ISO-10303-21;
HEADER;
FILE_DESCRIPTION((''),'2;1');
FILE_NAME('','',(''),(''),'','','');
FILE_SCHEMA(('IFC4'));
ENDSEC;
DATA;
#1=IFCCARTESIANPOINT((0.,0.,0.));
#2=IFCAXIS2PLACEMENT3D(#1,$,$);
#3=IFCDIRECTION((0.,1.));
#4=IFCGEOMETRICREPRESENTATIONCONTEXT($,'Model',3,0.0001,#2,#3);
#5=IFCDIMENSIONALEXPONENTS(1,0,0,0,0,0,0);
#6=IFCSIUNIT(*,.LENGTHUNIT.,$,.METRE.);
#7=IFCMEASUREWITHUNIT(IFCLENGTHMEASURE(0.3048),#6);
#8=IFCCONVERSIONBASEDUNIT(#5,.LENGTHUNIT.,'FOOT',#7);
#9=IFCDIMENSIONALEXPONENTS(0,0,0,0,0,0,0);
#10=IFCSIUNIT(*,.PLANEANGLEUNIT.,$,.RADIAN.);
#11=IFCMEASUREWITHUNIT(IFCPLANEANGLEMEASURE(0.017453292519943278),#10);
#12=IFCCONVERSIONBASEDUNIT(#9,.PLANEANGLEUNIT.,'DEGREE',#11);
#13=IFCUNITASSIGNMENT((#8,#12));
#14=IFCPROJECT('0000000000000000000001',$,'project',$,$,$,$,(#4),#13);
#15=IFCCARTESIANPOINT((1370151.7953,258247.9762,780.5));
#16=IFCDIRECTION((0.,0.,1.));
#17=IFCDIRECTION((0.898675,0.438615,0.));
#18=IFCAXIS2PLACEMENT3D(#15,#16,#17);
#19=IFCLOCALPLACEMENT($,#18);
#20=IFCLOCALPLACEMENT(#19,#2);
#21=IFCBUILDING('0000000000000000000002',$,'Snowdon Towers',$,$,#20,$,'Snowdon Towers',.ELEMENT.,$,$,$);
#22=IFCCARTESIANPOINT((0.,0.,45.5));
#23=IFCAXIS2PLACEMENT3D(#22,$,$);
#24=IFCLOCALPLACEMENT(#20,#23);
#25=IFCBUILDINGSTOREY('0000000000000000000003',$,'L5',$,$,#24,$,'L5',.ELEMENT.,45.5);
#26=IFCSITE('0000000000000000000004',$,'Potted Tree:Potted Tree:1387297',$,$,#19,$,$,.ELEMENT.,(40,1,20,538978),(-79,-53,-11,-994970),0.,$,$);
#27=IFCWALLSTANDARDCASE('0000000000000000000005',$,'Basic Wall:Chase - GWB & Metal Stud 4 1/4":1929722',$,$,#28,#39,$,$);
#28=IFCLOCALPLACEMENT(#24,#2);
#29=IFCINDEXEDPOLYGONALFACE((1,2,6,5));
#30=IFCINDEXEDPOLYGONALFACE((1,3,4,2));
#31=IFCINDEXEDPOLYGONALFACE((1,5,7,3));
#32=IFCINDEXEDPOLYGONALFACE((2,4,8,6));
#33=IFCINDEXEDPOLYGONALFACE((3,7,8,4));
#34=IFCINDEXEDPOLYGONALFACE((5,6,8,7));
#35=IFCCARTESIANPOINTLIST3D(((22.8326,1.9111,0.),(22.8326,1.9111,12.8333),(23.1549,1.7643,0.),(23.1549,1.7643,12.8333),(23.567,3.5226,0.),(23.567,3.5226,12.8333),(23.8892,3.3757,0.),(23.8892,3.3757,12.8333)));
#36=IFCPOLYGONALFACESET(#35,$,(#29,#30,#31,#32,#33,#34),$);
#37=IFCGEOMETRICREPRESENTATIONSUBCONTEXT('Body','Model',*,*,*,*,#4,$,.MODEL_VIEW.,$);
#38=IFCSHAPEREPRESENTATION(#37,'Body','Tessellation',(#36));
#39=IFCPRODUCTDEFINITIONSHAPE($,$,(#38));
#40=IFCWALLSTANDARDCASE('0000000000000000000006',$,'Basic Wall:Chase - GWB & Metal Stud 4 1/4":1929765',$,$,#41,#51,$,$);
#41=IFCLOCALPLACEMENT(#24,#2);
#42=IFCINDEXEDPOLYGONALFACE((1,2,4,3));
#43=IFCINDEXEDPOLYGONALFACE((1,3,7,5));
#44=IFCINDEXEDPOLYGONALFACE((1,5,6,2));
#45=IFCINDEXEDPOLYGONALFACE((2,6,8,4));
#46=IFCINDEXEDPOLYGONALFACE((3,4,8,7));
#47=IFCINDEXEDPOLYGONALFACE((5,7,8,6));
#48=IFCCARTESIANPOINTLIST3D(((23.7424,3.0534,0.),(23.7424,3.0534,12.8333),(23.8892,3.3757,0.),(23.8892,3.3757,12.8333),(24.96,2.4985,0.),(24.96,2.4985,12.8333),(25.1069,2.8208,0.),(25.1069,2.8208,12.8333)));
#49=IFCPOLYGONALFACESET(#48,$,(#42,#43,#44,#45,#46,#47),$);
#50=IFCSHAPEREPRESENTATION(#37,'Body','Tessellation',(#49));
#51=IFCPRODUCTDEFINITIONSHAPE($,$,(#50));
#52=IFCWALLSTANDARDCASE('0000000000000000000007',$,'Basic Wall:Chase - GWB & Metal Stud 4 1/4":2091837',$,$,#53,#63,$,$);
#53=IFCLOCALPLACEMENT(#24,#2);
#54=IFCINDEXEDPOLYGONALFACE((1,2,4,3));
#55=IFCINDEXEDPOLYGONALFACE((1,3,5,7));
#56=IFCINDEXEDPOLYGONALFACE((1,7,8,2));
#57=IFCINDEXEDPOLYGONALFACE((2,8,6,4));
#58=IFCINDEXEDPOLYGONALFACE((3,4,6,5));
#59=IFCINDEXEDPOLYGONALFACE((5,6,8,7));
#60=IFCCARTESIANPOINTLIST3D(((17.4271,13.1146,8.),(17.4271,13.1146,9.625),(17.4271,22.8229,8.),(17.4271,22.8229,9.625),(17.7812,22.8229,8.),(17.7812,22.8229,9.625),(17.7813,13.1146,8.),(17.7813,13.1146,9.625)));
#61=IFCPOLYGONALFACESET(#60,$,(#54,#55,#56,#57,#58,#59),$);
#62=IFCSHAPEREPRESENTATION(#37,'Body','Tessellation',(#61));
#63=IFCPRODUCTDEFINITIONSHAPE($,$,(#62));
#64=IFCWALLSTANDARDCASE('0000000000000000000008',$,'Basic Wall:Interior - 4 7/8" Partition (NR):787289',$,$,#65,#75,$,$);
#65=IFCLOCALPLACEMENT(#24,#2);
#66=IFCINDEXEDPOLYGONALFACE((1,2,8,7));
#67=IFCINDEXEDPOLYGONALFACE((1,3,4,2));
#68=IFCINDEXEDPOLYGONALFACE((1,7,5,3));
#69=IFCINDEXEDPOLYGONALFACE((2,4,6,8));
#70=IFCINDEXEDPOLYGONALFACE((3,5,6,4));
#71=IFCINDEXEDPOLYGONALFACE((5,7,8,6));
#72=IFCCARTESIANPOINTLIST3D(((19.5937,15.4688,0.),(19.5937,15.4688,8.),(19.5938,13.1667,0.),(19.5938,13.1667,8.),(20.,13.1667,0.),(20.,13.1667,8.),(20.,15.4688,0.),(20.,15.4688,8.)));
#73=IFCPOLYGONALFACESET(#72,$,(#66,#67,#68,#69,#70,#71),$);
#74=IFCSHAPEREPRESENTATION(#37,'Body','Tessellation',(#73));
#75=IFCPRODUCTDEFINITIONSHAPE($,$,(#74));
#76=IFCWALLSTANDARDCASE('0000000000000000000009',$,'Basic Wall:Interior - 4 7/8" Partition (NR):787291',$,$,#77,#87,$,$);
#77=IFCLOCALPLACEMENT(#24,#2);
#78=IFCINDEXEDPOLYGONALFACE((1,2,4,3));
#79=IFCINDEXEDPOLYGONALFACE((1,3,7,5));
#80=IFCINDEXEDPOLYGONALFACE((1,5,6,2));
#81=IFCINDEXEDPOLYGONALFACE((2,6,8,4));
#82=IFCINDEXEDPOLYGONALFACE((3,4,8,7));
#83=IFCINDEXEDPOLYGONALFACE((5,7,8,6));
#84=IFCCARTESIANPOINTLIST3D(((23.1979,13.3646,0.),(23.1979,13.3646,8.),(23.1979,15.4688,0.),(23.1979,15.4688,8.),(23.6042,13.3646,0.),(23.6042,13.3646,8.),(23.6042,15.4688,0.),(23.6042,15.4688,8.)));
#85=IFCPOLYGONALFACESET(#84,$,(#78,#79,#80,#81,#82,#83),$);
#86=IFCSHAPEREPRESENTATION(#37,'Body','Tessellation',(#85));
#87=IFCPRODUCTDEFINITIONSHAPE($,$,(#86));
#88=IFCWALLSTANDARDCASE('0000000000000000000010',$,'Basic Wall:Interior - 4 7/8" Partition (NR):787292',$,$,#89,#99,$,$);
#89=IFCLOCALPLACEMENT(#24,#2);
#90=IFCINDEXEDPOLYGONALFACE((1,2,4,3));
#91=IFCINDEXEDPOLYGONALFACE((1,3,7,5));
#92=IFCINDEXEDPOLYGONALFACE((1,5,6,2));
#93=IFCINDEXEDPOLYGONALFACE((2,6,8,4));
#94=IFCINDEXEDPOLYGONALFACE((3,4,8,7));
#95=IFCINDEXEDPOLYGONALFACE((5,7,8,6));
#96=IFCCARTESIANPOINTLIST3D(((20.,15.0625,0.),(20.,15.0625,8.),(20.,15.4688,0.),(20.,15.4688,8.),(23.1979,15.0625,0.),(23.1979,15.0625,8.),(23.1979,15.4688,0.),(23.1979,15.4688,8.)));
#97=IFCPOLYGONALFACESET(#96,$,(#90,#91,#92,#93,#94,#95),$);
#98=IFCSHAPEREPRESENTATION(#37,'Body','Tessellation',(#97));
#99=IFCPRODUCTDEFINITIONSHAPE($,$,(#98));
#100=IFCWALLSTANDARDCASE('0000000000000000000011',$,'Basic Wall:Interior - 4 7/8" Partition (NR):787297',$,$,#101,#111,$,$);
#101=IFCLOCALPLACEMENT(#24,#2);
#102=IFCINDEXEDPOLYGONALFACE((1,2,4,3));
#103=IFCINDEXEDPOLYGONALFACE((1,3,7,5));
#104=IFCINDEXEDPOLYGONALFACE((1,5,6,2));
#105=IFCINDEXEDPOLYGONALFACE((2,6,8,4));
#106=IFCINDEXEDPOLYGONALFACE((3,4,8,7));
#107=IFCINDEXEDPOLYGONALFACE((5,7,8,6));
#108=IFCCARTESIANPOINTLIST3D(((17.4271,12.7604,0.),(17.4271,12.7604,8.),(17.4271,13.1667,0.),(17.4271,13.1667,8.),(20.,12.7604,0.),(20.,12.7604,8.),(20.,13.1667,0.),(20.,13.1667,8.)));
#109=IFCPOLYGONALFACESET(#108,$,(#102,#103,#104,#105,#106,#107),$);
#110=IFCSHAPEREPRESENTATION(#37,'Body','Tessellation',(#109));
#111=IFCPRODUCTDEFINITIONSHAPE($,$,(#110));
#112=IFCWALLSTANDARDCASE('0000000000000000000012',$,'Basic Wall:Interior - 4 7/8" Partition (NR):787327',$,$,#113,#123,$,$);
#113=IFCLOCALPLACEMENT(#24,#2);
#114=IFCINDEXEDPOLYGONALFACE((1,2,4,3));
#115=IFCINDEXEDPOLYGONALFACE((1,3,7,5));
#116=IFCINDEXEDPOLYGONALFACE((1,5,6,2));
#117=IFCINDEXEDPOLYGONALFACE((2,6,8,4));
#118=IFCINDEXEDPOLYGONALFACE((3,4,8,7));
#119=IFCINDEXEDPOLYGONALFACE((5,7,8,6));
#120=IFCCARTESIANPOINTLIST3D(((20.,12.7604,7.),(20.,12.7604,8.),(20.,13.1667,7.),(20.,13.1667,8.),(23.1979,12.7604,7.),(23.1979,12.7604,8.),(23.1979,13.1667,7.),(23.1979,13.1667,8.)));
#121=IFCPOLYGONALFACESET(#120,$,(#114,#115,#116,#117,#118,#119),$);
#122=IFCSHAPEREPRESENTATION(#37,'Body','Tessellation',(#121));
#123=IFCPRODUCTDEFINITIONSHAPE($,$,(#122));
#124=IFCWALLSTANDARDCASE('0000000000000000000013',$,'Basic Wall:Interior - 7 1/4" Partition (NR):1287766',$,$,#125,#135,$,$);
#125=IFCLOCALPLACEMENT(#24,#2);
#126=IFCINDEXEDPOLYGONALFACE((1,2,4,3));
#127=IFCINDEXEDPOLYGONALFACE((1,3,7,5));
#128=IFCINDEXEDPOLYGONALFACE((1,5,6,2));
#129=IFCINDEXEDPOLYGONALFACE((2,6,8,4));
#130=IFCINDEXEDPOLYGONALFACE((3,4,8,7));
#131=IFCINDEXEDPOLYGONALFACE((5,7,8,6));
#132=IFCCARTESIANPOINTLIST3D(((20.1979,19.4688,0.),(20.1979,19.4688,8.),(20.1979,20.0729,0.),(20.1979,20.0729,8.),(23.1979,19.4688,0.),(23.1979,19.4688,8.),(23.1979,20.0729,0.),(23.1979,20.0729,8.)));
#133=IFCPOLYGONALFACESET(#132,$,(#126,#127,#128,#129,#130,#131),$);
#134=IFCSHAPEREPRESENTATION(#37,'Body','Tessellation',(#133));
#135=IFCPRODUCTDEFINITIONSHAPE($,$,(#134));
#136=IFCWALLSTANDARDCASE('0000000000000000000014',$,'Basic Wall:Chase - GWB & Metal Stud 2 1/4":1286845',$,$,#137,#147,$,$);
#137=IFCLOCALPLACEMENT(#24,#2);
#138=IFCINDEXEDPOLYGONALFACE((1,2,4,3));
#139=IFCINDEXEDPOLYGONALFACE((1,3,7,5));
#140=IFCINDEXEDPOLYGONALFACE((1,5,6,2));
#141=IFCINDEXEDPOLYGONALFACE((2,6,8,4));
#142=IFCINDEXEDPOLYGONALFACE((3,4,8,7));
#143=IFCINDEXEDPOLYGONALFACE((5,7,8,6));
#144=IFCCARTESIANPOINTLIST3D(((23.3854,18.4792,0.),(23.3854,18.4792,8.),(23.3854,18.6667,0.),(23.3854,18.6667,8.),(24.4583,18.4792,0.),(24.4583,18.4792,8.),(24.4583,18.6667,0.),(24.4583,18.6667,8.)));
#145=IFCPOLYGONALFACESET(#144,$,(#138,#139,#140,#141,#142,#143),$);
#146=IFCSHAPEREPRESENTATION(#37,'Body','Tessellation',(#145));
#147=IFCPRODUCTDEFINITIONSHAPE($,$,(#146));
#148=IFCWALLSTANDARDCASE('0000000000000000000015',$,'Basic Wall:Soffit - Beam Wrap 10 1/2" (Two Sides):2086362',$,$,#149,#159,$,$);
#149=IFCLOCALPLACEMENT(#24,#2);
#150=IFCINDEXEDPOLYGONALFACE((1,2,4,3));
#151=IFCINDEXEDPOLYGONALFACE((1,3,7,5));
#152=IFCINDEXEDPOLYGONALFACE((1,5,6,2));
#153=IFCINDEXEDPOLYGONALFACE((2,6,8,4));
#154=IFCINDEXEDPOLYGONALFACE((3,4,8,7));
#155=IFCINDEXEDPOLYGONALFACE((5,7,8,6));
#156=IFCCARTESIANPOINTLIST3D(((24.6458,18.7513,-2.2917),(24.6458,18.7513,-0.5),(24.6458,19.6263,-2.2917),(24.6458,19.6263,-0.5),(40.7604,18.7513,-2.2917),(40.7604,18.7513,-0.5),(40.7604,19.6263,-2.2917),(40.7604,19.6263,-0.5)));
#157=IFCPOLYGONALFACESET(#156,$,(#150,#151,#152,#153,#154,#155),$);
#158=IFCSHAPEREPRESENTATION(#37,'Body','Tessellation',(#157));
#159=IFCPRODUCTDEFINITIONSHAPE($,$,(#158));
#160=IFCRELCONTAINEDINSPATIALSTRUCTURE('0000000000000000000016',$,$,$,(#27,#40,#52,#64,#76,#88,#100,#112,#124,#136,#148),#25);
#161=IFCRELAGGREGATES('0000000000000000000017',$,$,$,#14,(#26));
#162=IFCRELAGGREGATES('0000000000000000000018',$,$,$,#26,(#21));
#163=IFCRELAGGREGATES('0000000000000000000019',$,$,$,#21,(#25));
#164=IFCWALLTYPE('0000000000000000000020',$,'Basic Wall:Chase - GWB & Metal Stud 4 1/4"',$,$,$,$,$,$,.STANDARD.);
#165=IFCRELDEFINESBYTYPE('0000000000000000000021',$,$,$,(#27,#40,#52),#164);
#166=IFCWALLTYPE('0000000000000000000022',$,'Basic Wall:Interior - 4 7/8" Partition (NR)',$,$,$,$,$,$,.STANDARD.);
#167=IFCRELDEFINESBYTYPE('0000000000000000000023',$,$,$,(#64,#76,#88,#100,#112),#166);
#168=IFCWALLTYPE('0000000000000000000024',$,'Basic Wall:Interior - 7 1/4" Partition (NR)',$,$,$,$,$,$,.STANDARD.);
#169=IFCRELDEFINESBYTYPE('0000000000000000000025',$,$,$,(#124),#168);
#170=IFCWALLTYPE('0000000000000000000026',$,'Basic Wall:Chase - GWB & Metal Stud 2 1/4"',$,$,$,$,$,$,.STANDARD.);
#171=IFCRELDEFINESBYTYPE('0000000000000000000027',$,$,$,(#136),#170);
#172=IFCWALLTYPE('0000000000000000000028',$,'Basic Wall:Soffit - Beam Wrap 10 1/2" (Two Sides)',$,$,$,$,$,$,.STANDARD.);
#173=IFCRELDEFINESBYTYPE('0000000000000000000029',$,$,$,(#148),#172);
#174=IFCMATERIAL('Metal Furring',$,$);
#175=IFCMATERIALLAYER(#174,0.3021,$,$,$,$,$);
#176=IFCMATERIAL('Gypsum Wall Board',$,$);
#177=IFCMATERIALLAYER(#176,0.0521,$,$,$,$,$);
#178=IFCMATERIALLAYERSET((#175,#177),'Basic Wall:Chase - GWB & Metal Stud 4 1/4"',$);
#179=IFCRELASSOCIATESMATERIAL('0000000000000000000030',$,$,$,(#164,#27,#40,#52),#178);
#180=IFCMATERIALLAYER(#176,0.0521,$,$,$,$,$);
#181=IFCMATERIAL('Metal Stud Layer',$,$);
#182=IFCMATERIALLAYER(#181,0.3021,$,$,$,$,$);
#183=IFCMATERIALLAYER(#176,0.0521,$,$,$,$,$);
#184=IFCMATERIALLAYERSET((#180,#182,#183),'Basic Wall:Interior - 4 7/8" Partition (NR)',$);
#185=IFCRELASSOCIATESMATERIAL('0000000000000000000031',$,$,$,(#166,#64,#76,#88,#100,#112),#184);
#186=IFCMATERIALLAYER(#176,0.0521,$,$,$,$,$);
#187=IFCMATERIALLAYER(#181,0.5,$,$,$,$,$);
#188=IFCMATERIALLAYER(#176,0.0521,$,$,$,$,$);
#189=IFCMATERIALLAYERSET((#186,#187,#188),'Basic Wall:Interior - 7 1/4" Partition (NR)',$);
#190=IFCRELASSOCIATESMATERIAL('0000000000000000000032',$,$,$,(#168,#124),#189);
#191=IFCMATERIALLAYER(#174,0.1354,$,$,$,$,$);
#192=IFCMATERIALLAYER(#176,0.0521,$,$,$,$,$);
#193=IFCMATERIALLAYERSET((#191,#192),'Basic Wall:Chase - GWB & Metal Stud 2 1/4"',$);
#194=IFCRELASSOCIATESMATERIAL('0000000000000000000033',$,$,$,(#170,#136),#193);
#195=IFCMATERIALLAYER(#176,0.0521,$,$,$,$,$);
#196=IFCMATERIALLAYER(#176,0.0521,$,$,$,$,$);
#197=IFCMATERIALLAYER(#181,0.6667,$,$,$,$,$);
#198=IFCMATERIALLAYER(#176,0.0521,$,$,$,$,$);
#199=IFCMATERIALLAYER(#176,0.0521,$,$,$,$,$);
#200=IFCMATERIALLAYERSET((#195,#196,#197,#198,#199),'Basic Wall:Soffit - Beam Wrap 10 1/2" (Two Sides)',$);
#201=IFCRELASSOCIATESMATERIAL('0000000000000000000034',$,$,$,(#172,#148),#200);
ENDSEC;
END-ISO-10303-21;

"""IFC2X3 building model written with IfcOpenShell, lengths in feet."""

from ifc_helpers import new_model, entity, si_unit, converted_unit, direction, frame, frame_2d, origin, place, context, subcontext, project, spatial, rectangle, extrude, material, layer, layer_set, layer_usage, type_object, element, save


model = new_model("IFC2X3")

# Units and contexts
model_context = context("Model", 3, precision=0.0001, world=origin(), true_north=direction((0.0, 1.0)))
body_context = subcontext(model_context, "Body", "Model", "MODEL_VIEW")
ifc_project = project(units=[converted_unit("LENGTHUNIT", "FOOT", entity("IfcLengthMeasure", 0.3048), si_unit("LENGTHUNIT", "METRE"), dimensions=[1, 0, 0, 0, 0, 0, 0]), converted_unit("PLANEANGLEUNIT", "DEGREE", entity("IfcPlaneAngleMeasure", 0.017453292519943278), si_unit("PLANEANGLEUNIT", "RADIAN"), dimensions=[0, 0, 0, 0, 0, 0, 0])], contexts=[model_context])

# Site, building, storey
site_placement = place(None, frame((1370151.7953, 258247.9762, 780.5), z_axis=(0.0, 0.0, 1.0), x_axis=(0.898675, 0.438615, 0.0)))
site = spatial("IfcSite", under=ifc_project, at=site_placement, Name="Potted Tree:Potted Tree:1387297", CompositionType="ELEMENT", RefLatitude=(40, 1, 20, 538978), RefLongitude=(-79, -53, -11, -994970), RefElevation=0.0)
building_placement = place(site_placement, origin())
building = spatial("IfcBuilding", under=site, at=building_placement, Name="Snowdon Towers", LongName="Snowdon Towers", CompositionType="ELEMENT")
storey_placement = place(building_placement, frame((0.0, 0.0, 45.5)))
storey = spatial("IfcBuildingStorey", under=building, at=storey_placement, Name="L5", LongName="L5", CompositionType="ELEMENT", Elevation=45.5)

# Walls
ifc_material_1 = material(Name="Metal Furring")
ifc_layer_1 = layer(ifc_material_1, 0.3021)
ifc_material_2 = material(Name="Gypsum Wall Board")
ifc_layer_2 = layer(ifc_material_2, 0.0521)
ifc_layer_set_1 = layer_set([ifc_layer_1, ifc_layer_2], Name="Basic Wall:Chase - GWB & Metal Stud 4 1/4\"")
ifc_layer_usage_1 = layer_usage(ifc_layer_set_1, "AXIS2", "POSITIVE", -0.1771)
wall_type_1 = type_object("IfcWallType", Name="Basic Wall:Chase - GWB & Metal Stud 4 1/4\"", PredefinedType="STANDARD", material=ifc_layer_set_1)
wall_1_placement = place(storey_placement, frame((22.9938, 1.8377, 0.0), z_axis=(0.0, 0.0, 1.0), x_axis=(0.414671, 0.909972, 0.0)))
element("IfcWallStandardCase", 1, at=wall_1_placement, inside=storey, type_object=wall_type_1, material=ifc_layer_usage_1, Name="Basic Wall:Chase - GWB & Metal Stud 4 1/4\":1929722", context=body_context, shape_type="SweptSolid", body=[
    extrude(rectangle(XDim=1.7708, YDim=0.3542, at=frame_2d((0.8854, 0.0), x_axis=(-1.0, 0.0))), origin(), (0.0, 0.0, 1.0), 12.8333),
])
ifc_layer_usage_2 = layer_usage(ifc_layer_set_1, "AXIS2", "POSITIVE", -0.1771)
wall_2_placement = place(storey_placement, frame((23.8158, 3.2145, 0.0), z_axis=(0.0, 0.0, 1.0), x_axis=(0.909972, -0.414671, 0.0)))
element("IfcWallStandardCase", 2, at=wall_2_placement, inside=storey, type_object=wall_type_1, material=ifc_layer_usage_2, Name="Basic Wall:Chase - GWB & Metal Stud 4 1/4\":1929765", context=body_context, shape_type="SweptSolid", body=[
    extrude(rectangle(XDim=1.3381, YDim=0.3542, at=frame_2d((0.6691, 0.0), x_axis=(-1.0, 0.0))), origin(), (0.0, 0.0, 1.0), 12.8333),
])
ifc_layer_usage_3 = layer_usage(ifc_layer_set_1, "AXIS2", "POSITIVE", -0.1771)
wall_3_placement = place(storey_placement, frame((17.6042, 13.1146, 8.0), z_axis=(0.0, 0.0, 1.0), x_axis=(0.0, 1.0, 0.0)))
element("IfcWallStandardCase", 3, at=wall_3_placement, inside=storey, type_object=wall_type_1, material=ifc_layer_usage_3, Name="Basic Wall:Chase - GWB & Metal Stud 4 1/4\":2091837", context=body_context, shape_type="SweptSolid", body=[
    extrude(rectangle(XDim=9.7083, YDim=0.3542, at=frame_2d((4.8542, 0.0), x_axis=(-1.0, 0.0))), origin(), (0.0, 0.0, 1.0), 1.625),
])
ifc_layer_3 = layer(ifc_material_2, 0.0521)
ifc_material_3 = material(Name="Metal Stud Layer")
ifc_layer_4 = layer(ifc_material_3, 0.3021)
ifc_layer_5 = layer(ifc_material_2, 0.0521)
ifc_layer_set_2 = layer_set([ifc_layer_3, ifc_layer_4, ifc_layer_5], Name="Basic Wall:Interior - 4 7/8\" Partition (NR)")
ifc_layer_usage_4 = layer_usage(ifc_layer_set_2, "AXIS2", "NEGATIVE", 0.2031)
wall_type_2 = type_object("IfcWallType", Name="Basic Wall:Interior - 4 7/8\" Partition (NR)", PredefinedType="STANDARD", material=ifc_layer_set_2)
wall_4_placement = place(storey_placement, frame((19.7969, 13.1667, 0.0), z_axis=(0.0, 0.0, 1.0), x_axis=(0.0, 1.0, 0.0)))
element("IfcWallStandardCase", 4, at=wall_4_placement, inside=storey, type_object=wall_type_2, material=ifc_layer_usage_4, Name="Basic Wall:Interior - 4 7/8\" Partition (NR):787289", context=body_context, shape_type="SweptSolid", body=[
    extrude(rectangle(XDim=2.3021, YDim=0.4062, at=frame_2d((1.151, 0.0), x_axis=(-1.0, 0.0))), origin(), (0.0, 0.0, 1.0), 8.0),
])
ifc_layer_usage_5 = layer_usage(ifc_layer_set_2, "AXIS2", "NEGATIVE", 0.2031)
wall_5_placement = place(storey_placement, frame((23.401, 13.3646, 0.0), z_axis=(0.0, 0.0, 1.0), x_axis=(0.0, 1.0, 0.0)))
element("IfcWallStandardCase", 5, at=wall_5_placement, inside=storey, type_object=wall_type_2, material=ifc_layer_usage_5, Name="Basic Wall:Interior - 4 7/8\" Partition (NR):787291", context=body_context, shape_type="SweptSolid", body=[
    extrude(rectangle(XDim=2.1042, YDim=0.4062, at=frame_2d((1.0521, 0.0), x_axis=(-1.0, 0.0))), origin(), (0.0, 0.0, 1.0), 8.0),
])
ifc_layer_usage_6 = layer_usage(ifc_layer_set_2, "AXIS2", "NEGATIVE", 0.2031)
wall_6_placement = place(storey_placement, frame((23.1979, 15.2656, 0.0), z_axis=(0.0, 0.0, 1.0), x_axis=(-1.0, 0.0, 0.0)))
element("IfcWallStandardCase", 6, at=wall_6_placement, inside=storey, type_object=wall_type_2, material=ifc_layer_usage_6, Name="Basic Wall:Interior - 4 7/8\" Partition (NR):787292", context=body_context, shape_type="SweptSolid", body=[
    extrude(rectangle(XDim=3.1979, YDim=0.4062, at=frame_2d((1.599, 0.0), x_axis=(-1.0, 0.0))), origin(), (0.0, 0.0, 1.0), 8.0),
])
ifc_layer_usage_7 = layer_usage(ifc_layer_set_2, "AXIS2", "NEGATIVE", 0.2031)
wall_7_placement = place(storey_placement, frame((20.0, 12.9635, 0.0), z_axis=(0.0, 0.0, 1.0), x_axis=(-1.0, 0.0, 0.0)))
element("IfcWallStandardCase", 7, at=wall_7_placement, inside=storey, type_object=wall_type_2, material=ifc_layer_usage_7, Name="Basic Wall:Interior - 4 7/8\" Partition (NR):787297", context=body_context, shape_type="SweptSolid", body=[
    extrude(rectangle(XDim=2.5729, YDim=0.4062, at=frame_2d((1.2865, 0.0), x_axis=(-1.0, 0.0))), origin(), (0.0, 0.0, 1.0), 8.0),
])
ifc_layer_usage_8 = layer_usage(ifc_layer_set_2, "AXIS2", "NEGATIVE", 0.2031)
wall_8_placement = place(storey_placement, frame((23.1979, 12.9635, 7.0), z_axis=(0.0, 0.0, 1.0), x_axis=(-1.0, 0.0, 0.0)))
element("IfcWallStandardCase", 8, at=wall_8_placement, inside=storey, type_object=wall_type_2, material=ifc_layer_usage_8, Name="Basic Wall:Interior - 4 7/8\" Partition (NR):787327", context=body_context, shape_type="SweptSolid", body=[
    extrude(rectangle(XDim=3.1979, YDim=0.4062, at=frame_2d((1.599, 0.0), x_axis=(-1.0, 0.0))), origin(), (0.0, 0.0, 1.0), 1.0),
])
ifc_layer_6 = layer(ifc_material_2, 0.0521)
ifc_layer_7 = layer(ifc_material_3, 0.5)
ifc_layer_8 = layer(ifc_material_2, 0.0521)
ifc_layer_set_3 = layer_set([ifc_layer_6, ifc_layer_7, ifc_layer_8], Name="Basic Wall:Interior - 7 1/4\" Partition (NR)")
wall_type_3 = type_object("IfcWallType", Name="Basic Wall:Interior - 7 1/4\" Partition (NR)", PredefinedType="STANDARD", material=ifc_layer_set_3)
ifc_layer_usage_9 = layer_usage(ifc_layer_set_3, "AXIS2", "NEGATIVE", 0.3021)
wall_9_placement = place(storey_placement, frame((20.1979, 19.7708, 0.0)))
element("IfcWallStandardCase", 9, at=wall_9_placement, inside=storey, type_object=wall_type_3, material=ifc_layer_usage_9, Name="Basic Wall:Interior - 7 1/4\" Partition (NR):1287766", context=body_context, shape_type="SweptSolid", body=[
    extrude(rectangle(XDim=3.0, YDim=0.6042, at=frame_2d((1.5, 0.0), x_axis=(-1.0, 0.0))), origin(), (0.0, 0.0, 1.0), 8.0),
])
ifc_layer_9 = layer(ifc_material_1, 0.1354)
ifc_layer_10 = layer(ifc_material_2, 0.0521)
ifc_layer_set_4 = layer_set([ifc_layer_9, ifc_layer_10], Name="Basic Wall:Chase - GWB & Metal Stud 2 1/4\"")
ifc_layer_usage_10 = layer_usage(ifc_layer_set_4, "AXIS2", "NEGATIVE", 0.0938)
wall_type_4 = type_object("IfcWallType", Name="Basic Wall:Chase - GWB & Metal Stud 2 1/4\"", PredefinedType="STANDARD", material=ifc_layer_set_4)
wall_10_placement = place(storey_placement, frame((23.3854, 18.5729, 0.0)))
element("IfcWallStandardCase", 10, at=wall_10_placement, inside=storey, type_object=wall_type_4, material=ifc_layer_usage_10, Name="Basic Wall:Chase - GWB & Metal Stud 2 1/4\":1286845", context=body_context, shape_type="SweptSolid", body=[
    extrude(rectangle(XDim=1.0729, YDim=0.1875, at=frame_2d((0.5365, 0.0), x_axis=(-1.0, 0.0))), origin(), (0.0, 0.0, 1.0), 8.0),
])
ifc_layer_11 = layer(ifc_material_2, 0.0521)
ifc_layer_12 = layer(ifc_material_2, 0.0521)
ifc_layer_13 = layer(ifc_material_3, 0.6667)
ifc_layer_14 = layer(ifc_material_2, 0.0521)
ifc_layer_15 = layer(ifc_material_2, 0.0521)
ifc_layer_set_5 = layer_set([ifc_layer_11, ifc_layer_12, ifc_layer_13, ifc_layer_14, ifc_layer_15], Name="Basic Wall:Soffit - Beam Wrap 10 1/2\" (Two Sides)")
ifc_layer_usage_11 = layer_usage(ifc_layer_set_5, "AXIS2", "NEGATIVE", 0.4375)
wall_type_5 = type_object("IfcWallType", Name="Basic Wall:Soffit - Beam Wrap 10 1/2\" (Two Sides)", PredefinedType="STANDARD", material=ifc_layer_set_5)
wall_11_placement = place(storey_placement, frame((24.6458, 19.1887, -2.2917)))
element("IfcWallStandardCase", 11, at=wall_11_placement, inside=storey, type_object=wall_type_5, material=ifc_layer_usage_11, Name="Basic Wall:Soffit - Beam Wrap 10 1/2\" (Two Sides):2086362", context=body_context, shape_type="SweptSolid", body=[
    extrude(rectangle(XDim=16.1146, YDim=0.875, at=frame_2d((8.0573, 0.0), x_axis=(-1.0, 0.0))), origin(), (0.0, 0.0, 1.0), 1.7917),
])

save(model, "model.ifc")
